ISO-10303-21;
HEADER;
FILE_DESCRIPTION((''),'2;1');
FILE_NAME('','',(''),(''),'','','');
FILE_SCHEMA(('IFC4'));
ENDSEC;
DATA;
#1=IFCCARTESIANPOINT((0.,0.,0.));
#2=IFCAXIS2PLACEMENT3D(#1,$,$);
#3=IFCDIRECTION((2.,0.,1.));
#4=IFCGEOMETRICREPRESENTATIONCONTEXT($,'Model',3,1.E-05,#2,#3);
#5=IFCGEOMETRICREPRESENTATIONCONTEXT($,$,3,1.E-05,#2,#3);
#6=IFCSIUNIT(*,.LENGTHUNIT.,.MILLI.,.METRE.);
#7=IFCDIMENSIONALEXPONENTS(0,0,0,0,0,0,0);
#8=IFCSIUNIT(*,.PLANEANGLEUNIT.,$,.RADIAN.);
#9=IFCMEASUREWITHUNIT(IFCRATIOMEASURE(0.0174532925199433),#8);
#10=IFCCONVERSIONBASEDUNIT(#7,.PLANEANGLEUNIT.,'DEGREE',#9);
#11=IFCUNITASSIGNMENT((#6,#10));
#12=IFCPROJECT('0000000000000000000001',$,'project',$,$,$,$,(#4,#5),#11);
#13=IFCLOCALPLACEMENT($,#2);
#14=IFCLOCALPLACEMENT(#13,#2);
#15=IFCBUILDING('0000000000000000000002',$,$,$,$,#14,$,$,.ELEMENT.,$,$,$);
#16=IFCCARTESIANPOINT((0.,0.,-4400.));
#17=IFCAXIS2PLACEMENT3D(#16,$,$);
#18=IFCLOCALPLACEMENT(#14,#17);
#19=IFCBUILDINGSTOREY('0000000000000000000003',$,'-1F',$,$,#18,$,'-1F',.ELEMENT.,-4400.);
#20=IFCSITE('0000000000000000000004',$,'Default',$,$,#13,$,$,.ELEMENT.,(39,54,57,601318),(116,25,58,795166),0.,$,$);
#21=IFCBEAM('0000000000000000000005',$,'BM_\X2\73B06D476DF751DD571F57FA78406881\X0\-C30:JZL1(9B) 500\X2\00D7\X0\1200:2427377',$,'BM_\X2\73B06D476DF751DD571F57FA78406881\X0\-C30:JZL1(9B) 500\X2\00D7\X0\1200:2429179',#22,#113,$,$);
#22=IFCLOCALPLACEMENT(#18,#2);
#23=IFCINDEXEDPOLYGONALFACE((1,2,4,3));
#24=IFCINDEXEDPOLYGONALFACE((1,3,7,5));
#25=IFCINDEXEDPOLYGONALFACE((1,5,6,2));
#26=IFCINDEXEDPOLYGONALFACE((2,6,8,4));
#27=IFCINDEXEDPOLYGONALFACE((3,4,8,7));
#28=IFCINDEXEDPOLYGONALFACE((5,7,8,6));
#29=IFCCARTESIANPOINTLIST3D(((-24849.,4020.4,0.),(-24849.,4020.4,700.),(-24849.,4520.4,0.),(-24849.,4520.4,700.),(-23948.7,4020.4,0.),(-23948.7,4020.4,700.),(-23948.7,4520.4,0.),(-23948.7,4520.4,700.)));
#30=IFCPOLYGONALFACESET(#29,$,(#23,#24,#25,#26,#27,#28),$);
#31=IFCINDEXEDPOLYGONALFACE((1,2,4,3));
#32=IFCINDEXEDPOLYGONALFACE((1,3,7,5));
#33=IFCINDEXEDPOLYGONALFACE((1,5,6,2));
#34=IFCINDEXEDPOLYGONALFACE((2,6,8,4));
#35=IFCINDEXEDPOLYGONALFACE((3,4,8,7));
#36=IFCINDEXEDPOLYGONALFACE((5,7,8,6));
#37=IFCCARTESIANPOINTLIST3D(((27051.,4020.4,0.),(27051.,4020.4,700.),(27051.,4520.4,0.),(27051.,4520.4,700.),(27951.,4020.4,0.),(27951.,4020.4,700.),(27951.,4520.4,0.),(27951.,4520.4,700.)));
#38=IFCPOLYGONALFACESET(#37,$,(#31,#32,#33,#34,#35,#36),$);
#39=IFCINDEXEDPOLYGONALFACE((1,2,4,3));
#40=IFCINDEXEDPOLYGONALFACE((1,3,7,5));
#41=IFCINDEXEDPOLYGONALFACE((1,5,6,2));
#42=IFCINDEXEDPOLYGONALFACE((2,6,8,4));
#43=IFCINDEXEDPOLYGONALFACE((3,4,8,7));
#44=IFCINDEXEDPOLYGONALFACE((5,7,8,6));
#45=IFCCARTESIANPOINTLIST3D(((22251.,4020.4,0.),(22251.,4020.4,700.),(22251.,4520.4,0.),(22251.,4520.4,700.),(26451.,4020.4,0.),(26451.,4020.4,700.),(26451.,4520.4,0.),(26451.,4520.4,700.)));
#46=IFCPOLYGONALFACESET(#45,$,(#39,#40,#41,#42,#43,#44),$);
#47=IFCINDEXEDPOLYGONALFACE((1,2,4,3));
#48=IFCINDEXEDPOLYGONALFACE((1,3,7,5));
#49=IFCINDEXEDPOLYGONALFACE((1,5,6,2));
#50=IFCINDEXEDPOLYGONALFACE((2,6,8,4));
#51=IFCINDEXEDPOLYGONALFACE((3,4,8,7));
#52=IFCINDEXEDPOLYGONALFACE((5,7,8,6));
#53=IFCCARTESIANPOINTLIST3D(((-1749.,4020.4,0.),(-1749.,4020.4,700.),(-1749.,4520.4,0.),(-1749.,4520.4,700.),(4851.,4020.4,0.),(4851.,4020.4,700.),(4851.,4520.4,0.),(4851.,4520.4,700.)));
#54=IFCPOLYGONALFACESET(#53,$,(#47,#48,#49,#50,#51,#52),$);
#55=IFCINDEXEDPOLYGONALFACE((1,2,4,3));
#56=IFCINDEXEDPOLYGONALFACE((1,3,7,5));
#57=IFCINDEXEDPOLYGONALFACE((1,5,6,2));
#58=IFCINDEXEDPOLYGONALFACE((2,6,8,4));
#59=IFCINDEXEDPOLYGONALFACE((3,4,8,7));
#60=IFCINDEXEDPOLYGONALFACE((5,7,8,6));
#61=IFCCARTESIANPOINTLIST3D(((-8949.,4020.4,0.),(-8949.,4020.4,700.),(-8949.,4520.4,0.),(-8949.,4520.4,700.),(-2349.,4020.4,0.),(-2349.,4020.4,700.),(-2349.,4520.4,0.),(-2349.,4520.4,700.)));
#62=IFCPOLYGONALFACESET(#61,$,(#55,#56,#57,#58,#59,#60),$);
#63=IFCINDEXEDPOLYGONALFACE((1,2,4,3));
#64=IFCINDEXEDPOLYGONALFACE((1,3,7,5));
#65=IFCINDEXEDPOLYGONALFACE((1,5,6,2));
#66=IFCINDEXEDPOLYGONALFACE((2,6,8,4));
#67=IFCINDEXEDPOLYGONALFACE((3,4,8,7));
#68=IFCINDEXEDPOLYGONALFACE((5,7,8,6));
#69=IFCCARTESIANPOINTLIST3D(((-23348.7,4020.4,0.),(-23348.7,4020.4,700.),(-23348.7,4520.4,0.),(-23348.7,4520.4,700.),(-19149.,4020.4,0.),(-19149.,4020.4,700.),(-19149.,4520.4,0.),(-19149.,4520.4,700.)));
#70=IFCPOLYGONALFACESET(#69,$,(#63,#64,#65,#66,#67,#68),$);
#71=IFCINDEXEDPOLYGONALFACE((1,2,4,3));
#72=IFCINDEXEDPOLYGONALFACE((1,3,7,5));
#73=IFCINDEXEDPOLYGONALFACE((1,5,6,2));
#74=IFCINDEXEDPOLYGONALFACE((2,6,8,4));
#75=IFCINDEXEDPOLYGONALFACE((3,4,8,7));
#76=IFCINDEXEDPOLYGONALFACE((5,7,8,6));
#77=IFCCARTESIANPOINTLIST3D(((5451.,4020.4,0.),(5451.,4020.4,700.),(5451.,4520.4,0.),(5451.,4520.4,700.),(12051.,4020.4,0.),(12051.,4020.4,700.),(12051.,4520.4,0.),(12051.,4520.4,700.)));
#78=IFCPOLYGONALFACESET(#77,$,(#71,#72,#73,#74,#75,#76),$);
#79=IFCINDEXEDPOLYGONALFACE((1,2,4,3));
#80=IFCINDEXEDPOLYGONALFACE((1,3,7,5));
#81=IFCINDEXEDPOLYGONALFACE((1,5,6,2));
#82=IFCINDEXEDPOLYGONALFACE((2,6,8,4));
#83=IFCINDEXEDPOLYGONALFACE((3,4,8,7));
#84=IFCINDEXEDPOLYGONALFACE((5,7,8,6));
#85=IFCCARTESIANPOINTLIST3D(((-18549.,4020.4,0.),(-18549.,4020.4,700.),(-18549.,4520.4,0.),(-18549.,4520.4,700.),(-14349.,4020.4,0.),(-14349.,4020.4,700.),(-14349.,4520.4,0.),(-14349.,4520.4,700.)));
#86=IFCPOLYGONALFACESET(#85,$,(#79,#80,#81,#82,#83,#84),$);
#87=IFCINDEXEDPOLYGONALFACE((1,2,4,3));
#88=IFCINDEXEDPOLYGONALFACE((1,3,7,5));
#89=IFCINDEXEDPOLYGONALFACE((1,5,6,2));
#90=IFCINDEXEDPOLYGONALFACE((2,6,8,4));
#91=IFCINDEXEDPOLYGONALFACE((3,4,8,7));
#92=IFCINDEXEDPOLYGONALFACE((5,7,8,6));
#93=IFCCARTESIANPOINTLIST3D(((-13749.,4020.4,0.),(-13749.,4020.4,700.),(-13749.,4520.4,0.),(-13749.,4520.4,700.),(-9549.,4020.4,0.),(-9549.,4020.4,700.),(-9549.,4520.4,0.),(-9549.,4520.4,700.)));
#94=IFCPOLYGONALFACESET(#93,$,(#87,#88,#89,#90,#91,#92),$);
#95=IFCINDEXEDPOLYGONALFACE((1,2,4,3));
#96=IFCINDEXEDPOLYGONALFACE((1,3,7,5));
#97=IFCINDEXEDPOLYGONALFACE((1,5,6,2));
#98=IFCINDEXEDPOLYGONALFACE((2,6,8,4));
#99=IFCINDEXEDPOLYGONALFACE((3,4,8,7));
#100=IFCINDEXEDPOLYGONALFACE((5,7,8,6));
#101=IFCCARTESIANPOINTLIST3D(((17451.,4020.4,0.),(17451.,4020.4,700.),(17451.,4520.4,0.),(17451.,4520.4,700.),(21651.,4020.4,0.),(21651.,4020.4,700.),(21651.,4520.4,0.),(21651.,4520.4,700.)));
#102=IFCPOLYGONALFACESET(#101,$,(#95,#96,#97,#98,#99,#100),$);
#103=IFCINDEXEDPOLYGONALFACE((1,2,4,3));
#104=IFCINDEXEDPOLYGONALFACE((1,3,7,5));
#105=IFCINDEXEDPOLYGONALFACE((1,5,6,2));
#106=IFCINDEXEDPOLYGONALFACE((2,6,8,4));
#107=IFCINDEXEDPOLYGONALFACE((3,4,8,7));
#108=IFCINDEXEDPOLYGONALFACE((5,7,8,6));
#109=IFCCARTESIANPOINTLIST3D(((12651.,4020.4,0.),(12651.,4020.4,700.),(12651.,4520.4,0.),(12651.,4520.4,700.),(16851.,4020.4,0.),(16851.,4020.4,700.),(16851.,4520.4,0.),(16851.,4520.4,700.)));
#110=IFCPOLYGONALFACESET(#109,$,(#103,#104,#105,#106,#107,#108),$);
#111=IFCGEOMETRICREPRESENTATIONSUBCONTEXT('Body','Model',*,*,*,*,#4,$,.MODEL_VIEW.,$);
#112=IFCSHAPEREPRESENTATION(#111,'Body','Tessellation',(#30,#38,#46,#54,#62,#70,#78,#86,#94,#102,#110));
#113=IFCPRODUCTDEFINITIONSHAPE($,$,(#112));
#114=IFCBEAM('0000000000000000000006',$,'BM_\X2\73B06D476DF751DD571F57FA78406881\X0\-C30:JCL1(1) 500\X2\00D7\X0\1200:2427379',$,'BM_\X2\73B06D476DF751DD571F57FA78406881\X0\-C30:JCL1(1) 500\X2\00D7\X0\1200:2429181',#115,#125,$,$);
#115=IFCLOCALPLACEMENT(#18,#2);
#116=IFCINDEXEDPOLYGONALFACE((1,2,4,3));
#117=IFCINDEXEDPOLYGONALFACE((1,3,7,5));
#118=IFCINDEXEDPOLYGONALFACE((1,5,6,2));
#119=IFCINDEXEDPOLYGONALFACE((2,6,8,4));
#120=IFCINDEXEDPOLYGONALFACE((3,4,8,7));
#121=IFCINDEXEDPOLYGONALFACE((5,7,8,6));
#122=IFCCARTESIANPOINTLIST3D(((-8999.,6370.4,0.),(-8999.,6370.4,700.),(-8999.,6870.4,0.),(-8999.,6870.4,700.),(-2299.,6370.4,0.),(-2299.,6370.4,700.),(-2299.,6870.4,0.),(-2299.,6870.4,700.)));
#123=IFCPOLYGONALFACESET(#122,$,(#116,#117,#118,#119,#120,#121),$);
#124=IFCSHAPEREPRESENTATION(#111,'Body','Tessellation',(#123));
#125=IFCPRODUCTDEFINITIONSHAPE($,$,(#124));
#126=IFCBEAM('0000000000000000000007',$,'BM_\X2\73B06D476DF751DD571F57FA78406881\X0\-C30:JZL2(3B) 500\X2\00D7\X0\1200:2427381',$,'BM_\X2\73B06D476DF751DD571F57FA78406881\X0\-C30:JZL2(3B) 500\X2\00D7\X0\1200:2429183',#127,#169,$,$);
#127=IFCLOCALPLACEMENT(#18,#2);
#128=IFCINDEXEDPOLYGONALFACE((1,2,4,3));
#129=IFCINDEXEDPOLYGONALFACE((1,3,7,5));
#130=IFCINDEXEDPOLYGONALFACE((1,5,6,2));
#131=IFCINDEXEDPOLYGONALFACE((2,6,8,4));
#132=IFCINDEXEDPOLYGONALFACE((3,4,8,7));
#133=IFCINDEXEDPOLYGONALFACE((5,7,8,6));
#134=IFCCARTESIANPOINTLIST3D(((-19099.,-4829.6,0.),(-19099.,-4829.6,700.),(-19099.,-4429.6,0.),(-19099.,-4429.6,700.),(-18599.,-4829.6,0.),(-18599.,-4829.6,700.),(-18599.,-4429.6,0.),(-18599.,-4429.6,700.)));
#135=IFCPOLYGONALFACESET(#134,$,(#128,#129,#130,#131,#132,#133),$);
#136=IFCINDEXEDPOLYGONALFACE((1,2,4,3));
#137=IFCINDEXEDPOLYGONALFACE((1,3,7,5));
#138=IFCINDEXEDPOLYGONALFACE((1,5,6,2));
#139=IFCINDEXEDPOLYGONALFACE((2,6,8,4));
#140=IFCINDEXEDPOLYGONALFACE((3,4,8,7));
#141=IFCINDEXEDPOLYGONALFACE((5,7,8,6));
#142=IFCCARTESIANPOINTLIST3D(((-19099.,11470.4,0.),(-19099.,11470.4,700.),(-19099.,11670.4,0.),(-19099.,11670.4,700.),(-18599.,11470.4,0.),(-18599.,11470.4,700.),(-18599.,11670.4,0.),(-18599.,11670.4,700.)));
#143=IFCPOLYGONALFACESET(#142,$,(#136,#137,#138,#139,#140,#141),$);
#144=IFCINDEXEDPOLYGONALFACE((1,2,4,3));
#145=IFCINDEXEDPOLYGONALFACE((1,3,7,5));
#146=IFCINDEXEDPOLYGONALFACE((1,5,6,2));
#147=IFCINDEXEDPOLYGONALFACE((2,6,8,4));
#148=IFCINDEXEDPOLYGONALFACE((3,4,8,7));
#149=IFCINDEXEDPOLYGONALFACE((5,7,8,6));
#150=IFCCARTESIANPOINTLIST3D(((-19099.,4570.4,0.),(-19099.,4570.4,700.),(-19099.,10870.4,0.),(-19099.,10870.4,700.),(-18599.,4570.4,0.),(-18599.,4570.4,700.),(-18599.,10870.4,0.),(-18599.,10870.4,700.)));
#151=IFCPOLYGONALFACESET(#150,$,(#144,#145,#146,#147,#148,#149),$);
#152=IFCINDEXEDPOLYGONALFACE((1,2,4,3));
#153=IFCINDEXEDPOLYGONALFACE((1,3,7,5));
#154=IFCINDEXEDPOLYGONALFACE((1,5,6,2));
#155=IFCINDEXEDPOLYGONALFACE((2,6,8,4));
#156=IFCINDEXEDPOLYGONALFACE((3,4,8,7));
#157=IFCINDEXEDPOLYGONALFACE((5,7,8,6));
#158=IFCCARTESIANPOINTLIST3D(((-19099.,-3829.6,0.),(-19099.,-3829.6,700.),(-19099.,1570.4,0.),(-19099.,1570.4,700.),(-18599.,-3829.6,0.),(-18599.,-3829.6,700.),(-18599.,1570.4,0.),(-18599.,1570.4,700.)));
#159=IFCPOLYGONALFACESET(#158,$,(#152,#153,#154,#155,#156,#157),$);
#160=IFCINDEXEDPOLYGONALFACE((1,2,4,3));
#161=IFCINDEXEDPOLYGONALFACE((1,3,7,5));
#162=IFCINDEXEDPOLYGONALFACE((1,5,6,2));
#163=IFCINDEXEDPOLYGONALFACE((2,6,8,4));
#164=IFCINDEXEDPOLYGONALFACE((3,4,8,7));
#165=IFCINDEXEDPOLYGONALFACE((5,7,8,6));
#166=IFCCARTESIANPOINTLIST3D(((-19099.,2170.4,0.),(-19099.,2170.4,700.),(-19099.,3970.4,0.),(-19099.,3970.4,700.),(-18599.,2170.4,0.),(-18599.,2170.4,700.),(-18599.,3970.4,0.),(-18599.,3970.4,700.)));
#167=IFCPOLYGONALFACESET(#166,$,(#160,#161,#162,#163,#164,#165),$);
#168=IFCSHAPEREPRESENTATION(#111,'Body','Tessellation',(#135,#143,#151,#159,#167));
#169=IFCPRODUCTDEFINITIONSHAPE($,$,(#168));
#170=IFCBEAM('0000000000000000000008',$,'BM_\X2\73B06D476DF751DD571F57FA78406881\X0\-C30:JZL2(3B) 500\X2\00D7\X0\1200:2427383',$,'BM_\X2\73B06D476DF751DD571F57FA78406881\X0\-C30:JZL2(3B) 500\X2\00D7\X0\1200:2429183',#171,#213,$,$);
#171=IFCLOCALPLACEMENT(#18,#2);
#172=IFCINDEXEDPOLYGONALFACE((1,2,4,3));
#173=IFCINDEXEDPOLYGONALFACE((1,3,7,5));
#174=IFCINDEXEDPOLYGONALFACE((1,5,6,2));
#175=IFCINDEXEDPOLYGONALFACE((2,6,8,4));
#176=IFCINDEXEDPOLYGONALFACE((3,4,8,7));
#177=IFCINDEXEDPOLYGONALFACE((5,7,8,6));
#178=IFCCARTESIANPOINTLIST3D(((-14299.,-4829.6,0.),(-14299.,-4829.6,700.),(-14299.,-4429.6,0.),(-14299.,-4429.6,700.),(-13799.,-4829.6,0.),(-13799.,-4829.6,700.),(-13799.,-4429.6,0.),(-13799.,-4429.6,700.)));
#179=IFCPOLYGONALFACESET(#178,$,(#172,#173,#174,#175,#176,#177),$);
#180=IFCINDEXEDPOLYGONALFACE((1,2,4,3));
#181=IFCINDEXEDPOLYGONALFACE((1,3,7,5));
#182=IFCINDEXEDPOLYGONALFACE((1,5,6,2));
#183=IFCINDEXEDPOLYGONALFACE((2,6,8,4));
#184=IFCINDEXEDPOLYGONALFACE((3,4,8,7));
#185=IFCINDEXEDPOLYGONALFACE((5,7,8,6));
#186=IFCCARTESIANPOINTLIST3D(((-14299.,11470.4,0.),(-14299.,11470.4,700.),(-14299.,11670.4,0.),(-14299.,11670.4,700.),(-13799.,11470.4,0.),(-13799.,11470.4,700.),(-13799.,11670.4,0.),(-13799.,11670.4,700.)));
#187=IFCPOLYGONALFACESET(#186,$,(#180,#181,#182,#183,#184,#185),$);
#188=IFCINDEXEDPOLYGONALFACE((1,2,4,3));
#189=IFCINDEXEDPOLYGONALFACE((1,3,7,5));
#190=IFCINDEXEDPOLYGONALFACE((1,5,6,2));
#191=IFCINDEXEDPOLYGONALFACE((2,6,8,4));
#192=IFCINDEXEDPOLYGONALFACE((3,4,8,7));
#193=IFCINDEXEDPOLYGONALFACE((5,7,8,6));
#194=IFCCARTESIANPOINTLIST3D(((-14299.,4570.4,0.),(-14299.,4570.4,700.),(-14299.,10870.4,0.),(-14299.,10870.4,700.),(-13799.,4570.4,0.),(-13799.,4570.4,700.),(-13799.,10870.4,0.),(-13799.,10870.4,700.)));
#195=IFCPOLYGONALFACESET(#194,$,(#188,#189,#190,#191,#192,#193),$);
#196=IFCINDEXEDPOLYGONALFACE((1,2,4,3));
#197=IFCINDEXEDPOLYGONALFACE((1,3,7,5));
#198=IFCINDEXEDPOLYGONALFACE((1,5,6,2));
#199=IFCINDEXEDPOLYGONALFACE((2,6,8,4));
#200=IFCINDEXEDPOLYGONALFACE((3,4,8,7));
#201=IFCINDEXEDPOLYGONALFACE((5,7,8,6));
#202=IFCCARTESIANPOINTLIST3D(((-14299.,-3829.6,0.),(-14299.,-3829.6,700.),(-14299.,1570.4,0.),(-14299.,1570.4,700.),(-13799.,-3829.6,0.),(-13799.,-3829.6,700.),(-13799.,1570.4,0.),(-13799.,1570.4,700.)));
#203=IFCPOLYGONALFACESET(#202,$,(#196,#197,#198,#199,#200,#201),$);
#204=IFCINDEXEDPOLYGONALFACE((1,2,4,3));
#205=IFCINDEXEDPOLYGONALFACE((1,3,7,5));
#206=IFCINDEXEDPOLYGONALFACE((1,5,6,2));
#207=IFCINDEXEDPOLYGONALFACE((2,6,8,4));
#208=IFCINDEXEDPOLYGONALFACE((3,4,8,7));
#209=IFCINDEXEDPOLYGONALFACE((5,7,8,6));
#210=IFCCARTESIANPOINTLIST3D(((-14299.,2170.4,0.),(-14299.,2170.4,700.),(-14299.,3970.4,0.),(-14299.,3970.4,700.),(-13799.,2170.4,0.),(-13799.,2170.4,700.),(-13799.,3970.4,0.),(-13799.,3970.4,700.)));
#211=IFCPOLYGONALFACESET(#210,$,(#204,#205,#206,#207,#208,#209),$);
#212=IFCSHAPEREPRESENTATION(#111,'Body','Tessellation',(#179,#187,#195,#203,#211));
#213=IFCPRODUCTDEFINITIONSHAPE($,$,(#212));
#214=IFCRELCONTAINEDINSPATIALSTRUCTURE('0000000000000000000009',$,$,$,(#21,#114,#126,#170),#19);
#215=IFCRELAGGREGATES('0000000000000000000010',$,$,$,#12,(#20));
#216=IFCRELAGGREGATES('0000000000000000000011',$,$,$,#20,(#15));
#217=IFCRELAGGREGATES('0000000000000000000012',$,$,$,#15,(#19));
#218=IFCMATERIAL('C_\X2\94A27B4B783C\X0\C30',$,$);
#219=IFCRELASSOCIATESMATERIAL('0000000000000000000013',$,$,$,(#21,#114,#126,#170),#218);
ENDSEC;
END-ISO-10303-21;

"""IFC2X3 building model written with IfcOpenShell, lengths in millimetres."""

from ifc_helpers import new_model, entity, si_unit, converted_unit, direction, frame, frame_2d, origin, origin_2d_with_axis, place, context, subcontext, project, spatial, rectangle, extrude, material, element, save


model = new_model("IFC2X3")

# Units and contexts
model_context = context("Model", 3, precision=1e-05, world=origin(), true_north=direction((2.0, 0.0, 1.0)))
context_of_model = context(None, 3, precision=1e-05, world=origin(), true_north=direction((2.0, 0.0, 1.0)))
body_context = subcontext(model_context, "Body", "Model", "MODEL_VIEW")
ifc_project = project(units=[si_unit("LENGTHUNIT", "METRE", prefix="MILLI"), converted_unit("PLANEANGLEUNIT", "DEGREE", entity("IfcRatioMeasure", 0.0174532925199433), si_unit("PLANEANGLEUNIT", "RADIAN"), dimensions=[0, 0, 0, 0, 0, 0, 0])], contexts=[model_context, context_of_model])

# Site, building, storey
site_placement = place(None, origin())
site = spatial("IfcSite", under=ifc_project, at=site_placement, Name="Default", CompositionType="ELEMENT", RefLatitude=(39, 54, 57, 601318), RefLongitude=(116, 25, 58, 795166), RefElevation=0.0)
building_placement = place(site_placement, origin())
building = spatial("IfcBuilding", under=site, at=building_placement, CompositionType="ELEMENT")
storey_placement = place(building_placement, frame((0.0, 0.0, -4400.0)))
storey = spatial("IfcBuildingStorey", under=building, at=storey_placement, Name="-1F", LongName="-1F", CompositionType="ELEMENT", Elevation=-4400.0)

# Beams
ifc_material_1 = material(Name="C_钢筋砼C30")
beam_1_placement = place(storey_placement, frame((-24849.0, 4270.4, -500.0)))
element("IfcBeam", 1, at=beam_1_placement, inside=storey, material=ifc_material_1, Name="BM_现浇混凝土基础梁-C30:JZL1(9B) 500×1200:2427377", ObjectType="BM_现浇混凝土基础梁-C30:JZL1(9B) 500×1200:2429179", context=body_context, shape_type="SweptSolid", body=[
    extrude(rectangle(XDim=700.0, YDim=500.0, at=origin_2d_with_axis()), frame((0.0, 0.0, 850.0), z_axis=(1.0, 0.0, 0.0), x_axis=(0.0, 0.0, -1.0)), (0.0, 0.0, 1.0), 900.4),
    extrude(rectangle(XDim=700.0, YDim=500.0, at=frame_2d((0.0, 0.0), x_axis=(1.0, 0.0))), frame((51900.0, 0.0, 850.0), z_axis=(1.0, 0.0, 0.0), x_axis=(0.0, 0.0, -1.0)), (0.0, 0.0, 1.0), 900.0),
    extrude(rectangle(XDim=700.0, YDim=500.0, at=frame_2d((0.0, 0.0), x_axis=(1.0, 0.0))), frame((47100.0, 0.0, 850.0), z_axis=(1.0, 0.0, 0.0), x_axis=(0.0, 0.0, -1.0)), (0.0, 0.0, 1.0), 4200.0),
    extrude(rectangle(XDim=700.0, YDim=500.0, at=frame_2d((0.0, 0.0), x_axis=(1.0, 0.0))), frame((23100.0, 0.0, 850.0), z_axis=(1.0, 0.0, 0.0), x_axis=(0.0, 0.0, -1.0)), (0.0, 0.0, 1.0), 6600.0),
    extrude(rectangle(XDim=700.0, YDim=500.0, at=frame_2d((0.0, 0.0), x_axis=(1.0, 0.0))), frame((15900.0, 0.0, 850.0), z_axis=(1.0, 0.0, 0.0), x_axis=(0.0, 0.0, -1.0)), (0.0, 0.0, 1.0), 6600.0),
    extrude(rectangle(XDim=700.0, YDim=500.0, at=origin_2d_with_axis()), frame((1500.4, 0.0, 850.0), z_axis=(1.0, 0.0, 0.0), x_axis=(0.0, 0.0, -1.0)), (0.0, 0.0, 1.0), 4199.6),
    extrude(rectangle(XDim=700.0, YDim=500.0, at=origin_2d_with_axis()), frame((30300.0, 0.0, 850.0), z_axis=(1.0, 0.0, 0.0), x_axis=(0.0, 0.0, -1.0)), (0.0, 0.0, 1.0), 6600.0),
    extrude(rectangle(XDim=700.0, YDim=500.0, at=origin_2d_with_axis()), frame((6300.0, 0.0, 850.0), z_axis=(1.0, 0.0, 0.0), x_axis=(0.0, 0.0, -1.0)), (0.0, 0.0, 1.0), 4200.0),
    extrude(rectangle(XDim=700.0, YDim=500.0, at=frame_2d((0.0, 0.0), x_axis=(1.0, 0.0))), frame((11100.0, 0.0, 850.0), z_axis=(1.0, 0.0, 0.0), x_axis=(0.0, 0.0, -1.0)), (0.0, 0.0, 1.0), 4200.0),
    extrude(rectangle(XDim=700.0, YDim=500.0, at=frame_2d((0.0, 0.0), x_axis=(1.0, 0.0))), frame((42300.0, 0.0, 850.0), z_axis=(1.0, 0.0, 0.0), x_axis=(0.0, 0.0, -1.0)), (0.0, 0.0, 1.0), 4200.0),
    extrude(rectangle(XDim=700.0, YDim=500.0, at=origin_2d_with_axis()), frame((37500.0, 0.0, 850.0), z_axis=(1.0, 0.0, 0.0), x_axis=(0.0, 0.0, -1.0)), (0.0, 0.0, 1.0), 4200.0),
])
beam_2_placement = place(storey_placement, frame((-9249.0, 6620.4, -500.0)))
element("IfcBeam", 2, at=beam_2_placement, inside=storey, material=ifc_material_1, Name="BM_现浇混凝土基础梁-C30:JCL1(1) 500×1200:2427379", ObjectType="BM_现浇混凝土基础梁-C30:JCL1(1) 500×1200:2429181", context=body_context, shape_type="SweptSolid", body=[
    extrude(rectangle(XDim=700.0, YDim=500.0, at=frame_2d((0.0, 0.0), x_axis=(1.0, 0.0))), frame((250.0, 0.0, 850.0), z_axis=(1.0, 0.0, 0.0), x_axis=(0.0, 0.0, -1.0)), (0.0, 0.0, 1.0), 6700.0),
])
beam_3_placement = place(storey_placement, frame((-18849.0, -4829.6, -500.0), z_axis=(0.0, 0.0, 1.0), x_axis=(0.0, 1.0, 0.0)))
element("IfcBeam", 3, at=beam_3_placement, inside=storey, material=ifc_material_1, Name="BM_现浇混凝土基础梁-C30:JZL2(3B) 500×1200:2427381", ObjectType="BM_现浇混凝土基础梁-C30:JZL2(3B) 500×1200:2429183", context=body_context, shape_type="SweptSolid", body=[
    extrude(rectangle(XDim=700.0, YDim=500.0, at=origin_2d_with_axis()), frame((0.0, 0.0, 850.0), z_axis=(1.0, 0.0, 0.0), x_axis=(0.0, 0.0, -1.0)), (0.0, 0.0, 1.0), 400.0),
    extrude(rectangle(XDim=700.0, YDim=500.0, at=origin_2d_with_axis()), frame((16300.0, 0.0, 850.0), z_axis=(1.0, 0.0, 0.0), x_axis=(0.0, 0.0, -1.0)), (0.0, 0.0, 1.0), 200.0),
    extrude(rectangle(XDim=700.0, YDim=500.0, at=origin_2d_with_axis()), frame((9400.0, 0.0, 850.0), z_axis=(1.0, 0.0, 0.0), x_axis=(0.0, 0.0, -1.0)), (0.0, 0.0, 1.0), 6300.0),
    extrude(rectangle(XDim=700.0, YDim=500.0, at=origin_2d_with_axis()), frame((1000.0, 0.0, 850.0), z_axis=(1.0, 0.0, 0.0), x_axis=(0.0, 0.0, -1.0)), (0.0, 0.0, 1.0), 5400.0),
    extrude(rectangle(XDim=700.0, YDim=500.0, at=frame_2d((0.0, 0.0), x_axis=(1.0, 0.0))), frame((7000.0, 0.0, 850.0), z_axis=(1.0, 0.0, 0.0), x_axis=(0.0, 0.0, -1.0)), (0.0, 0.0, 1.0), 1800.0),
])
beam_4_placement = place(storey_placement, frame((-14049.0, -4829.6, -500.0), z_axis=(0.0, 0.0, 1.0), x_axis=(0.0, 1.0, 0.0)))
element("IfcBeam", 4, at=beam_4_placement, inside=storey, material=ifc_material_1, Name="BM_现浇混凝土基础梁-C30:JZL2(3B) 500×1200:2427383", ObjectType="BM_现浇混凝土基础梁-C30:JZL2(3B) 500×1200:2429183", context=body_context, shape_type="SweptSolid", body=[
    extrude(rectangle(XDim=700.0, YDim=500.0, at=origin_2d_with_axis()), frame((0.0, 0.0, 850.0), z_axis=(1.0, 0.0, 0.0), x_axis=(0.0, 0.0, -1.0)), (0.0, 0.0, 1.0), 400.0),
    extrude(rectangle(XDim=700.0, YDim=500.0, at=origin_2d_with_axis()), frame((16300.0, 0.0, 850.0), z_axis=(1.0, 0.0, 0.0), x_axis=(0.0, 0.0, -1.0)), (0.0, 0.0, 1.0), 200.0),
    extrude(rectangle(XDim=700.0, YDim=500.0, at=origin_2d_with_axis()), frame((9400.0, 0.0, 850.0), z_axis=(1.0, 0.0, 0.0), x_axis=(0.0, 0.0, -1.0)), (0.0, 0.0, 1.0), 6300.0),
    extrude(rectangle(XDim=700.0, YDim=500.0, at=origin_2d_with_axis()), frame((1000.0, 0.0, 850.0), z_axis=(1.0, 0.0, 0.0), x_axis=(0.0, 0.0, -1.0)), (0.0, 0.0, 1.0), 5400.0),
    extrude(rectangle(XDim=700.0, YDim=500.0, at=origin_2d_with_axis()), frame((7000.0, 0.0, 850.0), z_axis=(1.0, 0.0, 0.0), x_axis=(0.0, 0.0, -1.0)), (0.0, 0.0, 1.0), 1800.0),
])

save(model, "model.ifc")
